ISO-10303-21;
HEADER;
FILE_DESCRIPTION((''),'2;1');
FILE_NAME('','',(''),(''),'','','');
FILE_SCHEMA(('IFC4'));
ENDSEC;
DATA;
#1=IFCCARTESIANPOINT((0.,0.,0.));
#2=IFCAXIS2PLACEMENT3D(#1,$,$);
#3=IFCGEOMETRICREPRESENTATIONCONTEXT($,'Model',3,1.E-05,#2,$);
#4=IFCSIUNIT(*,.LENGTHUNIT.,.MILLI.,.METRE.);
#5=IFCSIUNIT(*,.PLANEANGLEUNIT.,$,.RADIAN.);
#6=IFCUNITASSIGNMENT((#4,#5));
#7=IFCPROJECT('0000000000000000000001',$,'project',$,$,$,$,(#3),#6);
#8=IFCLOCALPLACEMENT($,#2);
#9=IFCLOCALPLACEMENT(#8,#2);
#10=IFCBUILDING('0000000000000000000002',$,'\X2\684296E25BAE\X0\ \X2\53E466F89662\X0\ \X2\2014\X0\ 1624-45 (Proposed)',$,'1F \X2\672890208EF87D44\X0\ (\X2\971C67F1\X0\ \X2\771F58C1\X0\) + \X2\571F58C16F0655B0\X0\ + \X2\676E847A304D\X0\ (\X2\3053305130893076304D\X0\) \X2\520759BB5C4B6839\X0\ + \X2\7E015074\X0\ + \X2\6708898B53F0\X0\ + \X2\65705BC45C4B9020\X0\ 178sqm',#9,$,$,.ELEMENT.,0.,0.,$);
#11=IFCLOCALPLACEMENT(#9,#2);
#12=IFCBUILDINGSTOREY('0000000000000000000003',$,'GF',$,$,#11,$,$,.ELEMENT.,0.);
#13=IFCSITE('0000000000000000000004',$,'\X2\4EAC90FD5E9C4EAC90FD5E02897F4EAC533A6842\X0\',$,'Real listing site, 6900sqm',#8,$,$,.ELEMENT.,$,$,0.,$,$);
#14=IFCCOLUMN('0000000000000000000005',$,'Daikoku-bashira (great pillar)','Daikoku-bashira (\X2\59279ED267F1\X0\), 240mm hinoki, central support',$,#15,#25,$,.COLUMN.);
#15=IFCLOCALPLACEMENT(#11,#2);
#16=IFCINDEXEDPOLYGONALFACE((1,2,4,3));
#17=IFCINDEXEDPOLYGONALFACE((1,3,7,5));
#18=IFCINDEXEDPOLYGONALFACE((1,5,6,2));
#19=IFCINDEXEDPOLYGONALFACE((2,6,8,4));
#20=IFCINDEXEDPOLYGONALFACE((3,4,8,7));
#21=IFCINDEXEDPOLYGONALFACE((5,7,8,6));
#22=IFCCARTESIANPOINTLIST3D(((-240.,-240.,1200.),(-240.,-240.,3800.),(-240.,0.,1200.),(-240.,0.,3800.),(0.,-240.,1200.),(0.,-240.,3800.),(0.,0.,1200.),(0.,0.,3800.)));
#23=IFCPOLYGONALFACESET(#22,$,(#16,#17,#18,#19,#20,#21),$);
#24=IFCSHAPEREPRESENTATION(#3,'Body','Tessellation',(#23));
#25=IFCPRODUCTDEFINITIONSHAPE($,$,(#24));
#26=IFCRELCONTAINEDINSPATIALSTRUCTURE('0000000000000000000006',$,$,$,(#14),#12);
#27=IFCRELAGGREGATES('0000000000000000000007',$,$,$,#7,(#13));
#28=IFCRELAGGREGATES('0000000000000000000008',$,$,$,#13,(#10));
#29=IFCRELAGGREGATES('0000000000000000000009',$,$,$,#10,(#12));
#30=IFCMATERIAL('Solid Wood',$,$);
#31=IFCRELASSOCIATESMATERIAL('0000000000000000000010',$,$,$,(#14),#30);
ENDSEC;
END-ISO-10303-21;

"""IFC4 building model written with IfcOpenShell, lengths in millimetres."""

from ifc_helpers import new_model, si_unit, frame, frame_2d, origin, place, context, project, spatial, rectangle, extrude, material, element, save


model = new_model("IFC4")

# Units and contexts
model_context = context("Model", 3, precision=1e-05, world=origin())
ifc_project = project(units=[si_unit("LENGTHUNIT", "METRE", prefix="MILLI"), si_unit("PLANEANGLEUNIT", "RADIAN")], contexts=[model_context])

# Site, building, storey
site_placement = place(None, origin())
site = spatial("IfcSite", under=ifc_project, at=site_placement, Name="京都府京都市西京区桂", ObjectType="Real listing site, 6900sqm", CompositionType="ELEMENT", RefElevation=0.0)
building_placement = place(site_placement, origin())
building = spatial("IfcBuilding", under=site, at=building_placement, Name="桂離宮 古書院 — 1624-45 (Proposed)", ObjectType="1F 木造軸組 (霜柱 真壁) + 土壁漆喰 + 杮葺き (こけらぶき) 切妻屋根 + 縁側 + 月見台 + 数寄屋造 178sqm", CompositionType="ELEMENT", ElevationOfRefHeight=0.0, ElevationOfTerrain=0.0)
storey_placement = place(building_placement, origin())
storey = spatial("IfcBuildingStorey", under=building, at=storey_placement, Name="GF", CompositionType="ELEMENT", Elevation=0.0)

# Column
ifc_material_1 = material(Name="Solid Wood")
column_1_placement = place(storey_placement, frame((-120.0, -120.0, 600.0)))
element("IfcColumn", 1, at=column_1_placement, inside=storey, material=ifc_material_1, Name="Daikoku-bashira (great pillar)", Description="Daikoku-bashira (大黒柱), 240mm hinoki, central support", PredefinedType="COLUMN", context=model_context, shape_type="SweptSolid", body=[
    extrude(rectangle(XDim=240.0, YDim=240.0, at=frame_2d((120.0, 120.0))), frame((-120.0, -120.0, 600.0)), (0.0, 0.0, 1.0), 2600.0),
])

save(model, "model.ifc")
